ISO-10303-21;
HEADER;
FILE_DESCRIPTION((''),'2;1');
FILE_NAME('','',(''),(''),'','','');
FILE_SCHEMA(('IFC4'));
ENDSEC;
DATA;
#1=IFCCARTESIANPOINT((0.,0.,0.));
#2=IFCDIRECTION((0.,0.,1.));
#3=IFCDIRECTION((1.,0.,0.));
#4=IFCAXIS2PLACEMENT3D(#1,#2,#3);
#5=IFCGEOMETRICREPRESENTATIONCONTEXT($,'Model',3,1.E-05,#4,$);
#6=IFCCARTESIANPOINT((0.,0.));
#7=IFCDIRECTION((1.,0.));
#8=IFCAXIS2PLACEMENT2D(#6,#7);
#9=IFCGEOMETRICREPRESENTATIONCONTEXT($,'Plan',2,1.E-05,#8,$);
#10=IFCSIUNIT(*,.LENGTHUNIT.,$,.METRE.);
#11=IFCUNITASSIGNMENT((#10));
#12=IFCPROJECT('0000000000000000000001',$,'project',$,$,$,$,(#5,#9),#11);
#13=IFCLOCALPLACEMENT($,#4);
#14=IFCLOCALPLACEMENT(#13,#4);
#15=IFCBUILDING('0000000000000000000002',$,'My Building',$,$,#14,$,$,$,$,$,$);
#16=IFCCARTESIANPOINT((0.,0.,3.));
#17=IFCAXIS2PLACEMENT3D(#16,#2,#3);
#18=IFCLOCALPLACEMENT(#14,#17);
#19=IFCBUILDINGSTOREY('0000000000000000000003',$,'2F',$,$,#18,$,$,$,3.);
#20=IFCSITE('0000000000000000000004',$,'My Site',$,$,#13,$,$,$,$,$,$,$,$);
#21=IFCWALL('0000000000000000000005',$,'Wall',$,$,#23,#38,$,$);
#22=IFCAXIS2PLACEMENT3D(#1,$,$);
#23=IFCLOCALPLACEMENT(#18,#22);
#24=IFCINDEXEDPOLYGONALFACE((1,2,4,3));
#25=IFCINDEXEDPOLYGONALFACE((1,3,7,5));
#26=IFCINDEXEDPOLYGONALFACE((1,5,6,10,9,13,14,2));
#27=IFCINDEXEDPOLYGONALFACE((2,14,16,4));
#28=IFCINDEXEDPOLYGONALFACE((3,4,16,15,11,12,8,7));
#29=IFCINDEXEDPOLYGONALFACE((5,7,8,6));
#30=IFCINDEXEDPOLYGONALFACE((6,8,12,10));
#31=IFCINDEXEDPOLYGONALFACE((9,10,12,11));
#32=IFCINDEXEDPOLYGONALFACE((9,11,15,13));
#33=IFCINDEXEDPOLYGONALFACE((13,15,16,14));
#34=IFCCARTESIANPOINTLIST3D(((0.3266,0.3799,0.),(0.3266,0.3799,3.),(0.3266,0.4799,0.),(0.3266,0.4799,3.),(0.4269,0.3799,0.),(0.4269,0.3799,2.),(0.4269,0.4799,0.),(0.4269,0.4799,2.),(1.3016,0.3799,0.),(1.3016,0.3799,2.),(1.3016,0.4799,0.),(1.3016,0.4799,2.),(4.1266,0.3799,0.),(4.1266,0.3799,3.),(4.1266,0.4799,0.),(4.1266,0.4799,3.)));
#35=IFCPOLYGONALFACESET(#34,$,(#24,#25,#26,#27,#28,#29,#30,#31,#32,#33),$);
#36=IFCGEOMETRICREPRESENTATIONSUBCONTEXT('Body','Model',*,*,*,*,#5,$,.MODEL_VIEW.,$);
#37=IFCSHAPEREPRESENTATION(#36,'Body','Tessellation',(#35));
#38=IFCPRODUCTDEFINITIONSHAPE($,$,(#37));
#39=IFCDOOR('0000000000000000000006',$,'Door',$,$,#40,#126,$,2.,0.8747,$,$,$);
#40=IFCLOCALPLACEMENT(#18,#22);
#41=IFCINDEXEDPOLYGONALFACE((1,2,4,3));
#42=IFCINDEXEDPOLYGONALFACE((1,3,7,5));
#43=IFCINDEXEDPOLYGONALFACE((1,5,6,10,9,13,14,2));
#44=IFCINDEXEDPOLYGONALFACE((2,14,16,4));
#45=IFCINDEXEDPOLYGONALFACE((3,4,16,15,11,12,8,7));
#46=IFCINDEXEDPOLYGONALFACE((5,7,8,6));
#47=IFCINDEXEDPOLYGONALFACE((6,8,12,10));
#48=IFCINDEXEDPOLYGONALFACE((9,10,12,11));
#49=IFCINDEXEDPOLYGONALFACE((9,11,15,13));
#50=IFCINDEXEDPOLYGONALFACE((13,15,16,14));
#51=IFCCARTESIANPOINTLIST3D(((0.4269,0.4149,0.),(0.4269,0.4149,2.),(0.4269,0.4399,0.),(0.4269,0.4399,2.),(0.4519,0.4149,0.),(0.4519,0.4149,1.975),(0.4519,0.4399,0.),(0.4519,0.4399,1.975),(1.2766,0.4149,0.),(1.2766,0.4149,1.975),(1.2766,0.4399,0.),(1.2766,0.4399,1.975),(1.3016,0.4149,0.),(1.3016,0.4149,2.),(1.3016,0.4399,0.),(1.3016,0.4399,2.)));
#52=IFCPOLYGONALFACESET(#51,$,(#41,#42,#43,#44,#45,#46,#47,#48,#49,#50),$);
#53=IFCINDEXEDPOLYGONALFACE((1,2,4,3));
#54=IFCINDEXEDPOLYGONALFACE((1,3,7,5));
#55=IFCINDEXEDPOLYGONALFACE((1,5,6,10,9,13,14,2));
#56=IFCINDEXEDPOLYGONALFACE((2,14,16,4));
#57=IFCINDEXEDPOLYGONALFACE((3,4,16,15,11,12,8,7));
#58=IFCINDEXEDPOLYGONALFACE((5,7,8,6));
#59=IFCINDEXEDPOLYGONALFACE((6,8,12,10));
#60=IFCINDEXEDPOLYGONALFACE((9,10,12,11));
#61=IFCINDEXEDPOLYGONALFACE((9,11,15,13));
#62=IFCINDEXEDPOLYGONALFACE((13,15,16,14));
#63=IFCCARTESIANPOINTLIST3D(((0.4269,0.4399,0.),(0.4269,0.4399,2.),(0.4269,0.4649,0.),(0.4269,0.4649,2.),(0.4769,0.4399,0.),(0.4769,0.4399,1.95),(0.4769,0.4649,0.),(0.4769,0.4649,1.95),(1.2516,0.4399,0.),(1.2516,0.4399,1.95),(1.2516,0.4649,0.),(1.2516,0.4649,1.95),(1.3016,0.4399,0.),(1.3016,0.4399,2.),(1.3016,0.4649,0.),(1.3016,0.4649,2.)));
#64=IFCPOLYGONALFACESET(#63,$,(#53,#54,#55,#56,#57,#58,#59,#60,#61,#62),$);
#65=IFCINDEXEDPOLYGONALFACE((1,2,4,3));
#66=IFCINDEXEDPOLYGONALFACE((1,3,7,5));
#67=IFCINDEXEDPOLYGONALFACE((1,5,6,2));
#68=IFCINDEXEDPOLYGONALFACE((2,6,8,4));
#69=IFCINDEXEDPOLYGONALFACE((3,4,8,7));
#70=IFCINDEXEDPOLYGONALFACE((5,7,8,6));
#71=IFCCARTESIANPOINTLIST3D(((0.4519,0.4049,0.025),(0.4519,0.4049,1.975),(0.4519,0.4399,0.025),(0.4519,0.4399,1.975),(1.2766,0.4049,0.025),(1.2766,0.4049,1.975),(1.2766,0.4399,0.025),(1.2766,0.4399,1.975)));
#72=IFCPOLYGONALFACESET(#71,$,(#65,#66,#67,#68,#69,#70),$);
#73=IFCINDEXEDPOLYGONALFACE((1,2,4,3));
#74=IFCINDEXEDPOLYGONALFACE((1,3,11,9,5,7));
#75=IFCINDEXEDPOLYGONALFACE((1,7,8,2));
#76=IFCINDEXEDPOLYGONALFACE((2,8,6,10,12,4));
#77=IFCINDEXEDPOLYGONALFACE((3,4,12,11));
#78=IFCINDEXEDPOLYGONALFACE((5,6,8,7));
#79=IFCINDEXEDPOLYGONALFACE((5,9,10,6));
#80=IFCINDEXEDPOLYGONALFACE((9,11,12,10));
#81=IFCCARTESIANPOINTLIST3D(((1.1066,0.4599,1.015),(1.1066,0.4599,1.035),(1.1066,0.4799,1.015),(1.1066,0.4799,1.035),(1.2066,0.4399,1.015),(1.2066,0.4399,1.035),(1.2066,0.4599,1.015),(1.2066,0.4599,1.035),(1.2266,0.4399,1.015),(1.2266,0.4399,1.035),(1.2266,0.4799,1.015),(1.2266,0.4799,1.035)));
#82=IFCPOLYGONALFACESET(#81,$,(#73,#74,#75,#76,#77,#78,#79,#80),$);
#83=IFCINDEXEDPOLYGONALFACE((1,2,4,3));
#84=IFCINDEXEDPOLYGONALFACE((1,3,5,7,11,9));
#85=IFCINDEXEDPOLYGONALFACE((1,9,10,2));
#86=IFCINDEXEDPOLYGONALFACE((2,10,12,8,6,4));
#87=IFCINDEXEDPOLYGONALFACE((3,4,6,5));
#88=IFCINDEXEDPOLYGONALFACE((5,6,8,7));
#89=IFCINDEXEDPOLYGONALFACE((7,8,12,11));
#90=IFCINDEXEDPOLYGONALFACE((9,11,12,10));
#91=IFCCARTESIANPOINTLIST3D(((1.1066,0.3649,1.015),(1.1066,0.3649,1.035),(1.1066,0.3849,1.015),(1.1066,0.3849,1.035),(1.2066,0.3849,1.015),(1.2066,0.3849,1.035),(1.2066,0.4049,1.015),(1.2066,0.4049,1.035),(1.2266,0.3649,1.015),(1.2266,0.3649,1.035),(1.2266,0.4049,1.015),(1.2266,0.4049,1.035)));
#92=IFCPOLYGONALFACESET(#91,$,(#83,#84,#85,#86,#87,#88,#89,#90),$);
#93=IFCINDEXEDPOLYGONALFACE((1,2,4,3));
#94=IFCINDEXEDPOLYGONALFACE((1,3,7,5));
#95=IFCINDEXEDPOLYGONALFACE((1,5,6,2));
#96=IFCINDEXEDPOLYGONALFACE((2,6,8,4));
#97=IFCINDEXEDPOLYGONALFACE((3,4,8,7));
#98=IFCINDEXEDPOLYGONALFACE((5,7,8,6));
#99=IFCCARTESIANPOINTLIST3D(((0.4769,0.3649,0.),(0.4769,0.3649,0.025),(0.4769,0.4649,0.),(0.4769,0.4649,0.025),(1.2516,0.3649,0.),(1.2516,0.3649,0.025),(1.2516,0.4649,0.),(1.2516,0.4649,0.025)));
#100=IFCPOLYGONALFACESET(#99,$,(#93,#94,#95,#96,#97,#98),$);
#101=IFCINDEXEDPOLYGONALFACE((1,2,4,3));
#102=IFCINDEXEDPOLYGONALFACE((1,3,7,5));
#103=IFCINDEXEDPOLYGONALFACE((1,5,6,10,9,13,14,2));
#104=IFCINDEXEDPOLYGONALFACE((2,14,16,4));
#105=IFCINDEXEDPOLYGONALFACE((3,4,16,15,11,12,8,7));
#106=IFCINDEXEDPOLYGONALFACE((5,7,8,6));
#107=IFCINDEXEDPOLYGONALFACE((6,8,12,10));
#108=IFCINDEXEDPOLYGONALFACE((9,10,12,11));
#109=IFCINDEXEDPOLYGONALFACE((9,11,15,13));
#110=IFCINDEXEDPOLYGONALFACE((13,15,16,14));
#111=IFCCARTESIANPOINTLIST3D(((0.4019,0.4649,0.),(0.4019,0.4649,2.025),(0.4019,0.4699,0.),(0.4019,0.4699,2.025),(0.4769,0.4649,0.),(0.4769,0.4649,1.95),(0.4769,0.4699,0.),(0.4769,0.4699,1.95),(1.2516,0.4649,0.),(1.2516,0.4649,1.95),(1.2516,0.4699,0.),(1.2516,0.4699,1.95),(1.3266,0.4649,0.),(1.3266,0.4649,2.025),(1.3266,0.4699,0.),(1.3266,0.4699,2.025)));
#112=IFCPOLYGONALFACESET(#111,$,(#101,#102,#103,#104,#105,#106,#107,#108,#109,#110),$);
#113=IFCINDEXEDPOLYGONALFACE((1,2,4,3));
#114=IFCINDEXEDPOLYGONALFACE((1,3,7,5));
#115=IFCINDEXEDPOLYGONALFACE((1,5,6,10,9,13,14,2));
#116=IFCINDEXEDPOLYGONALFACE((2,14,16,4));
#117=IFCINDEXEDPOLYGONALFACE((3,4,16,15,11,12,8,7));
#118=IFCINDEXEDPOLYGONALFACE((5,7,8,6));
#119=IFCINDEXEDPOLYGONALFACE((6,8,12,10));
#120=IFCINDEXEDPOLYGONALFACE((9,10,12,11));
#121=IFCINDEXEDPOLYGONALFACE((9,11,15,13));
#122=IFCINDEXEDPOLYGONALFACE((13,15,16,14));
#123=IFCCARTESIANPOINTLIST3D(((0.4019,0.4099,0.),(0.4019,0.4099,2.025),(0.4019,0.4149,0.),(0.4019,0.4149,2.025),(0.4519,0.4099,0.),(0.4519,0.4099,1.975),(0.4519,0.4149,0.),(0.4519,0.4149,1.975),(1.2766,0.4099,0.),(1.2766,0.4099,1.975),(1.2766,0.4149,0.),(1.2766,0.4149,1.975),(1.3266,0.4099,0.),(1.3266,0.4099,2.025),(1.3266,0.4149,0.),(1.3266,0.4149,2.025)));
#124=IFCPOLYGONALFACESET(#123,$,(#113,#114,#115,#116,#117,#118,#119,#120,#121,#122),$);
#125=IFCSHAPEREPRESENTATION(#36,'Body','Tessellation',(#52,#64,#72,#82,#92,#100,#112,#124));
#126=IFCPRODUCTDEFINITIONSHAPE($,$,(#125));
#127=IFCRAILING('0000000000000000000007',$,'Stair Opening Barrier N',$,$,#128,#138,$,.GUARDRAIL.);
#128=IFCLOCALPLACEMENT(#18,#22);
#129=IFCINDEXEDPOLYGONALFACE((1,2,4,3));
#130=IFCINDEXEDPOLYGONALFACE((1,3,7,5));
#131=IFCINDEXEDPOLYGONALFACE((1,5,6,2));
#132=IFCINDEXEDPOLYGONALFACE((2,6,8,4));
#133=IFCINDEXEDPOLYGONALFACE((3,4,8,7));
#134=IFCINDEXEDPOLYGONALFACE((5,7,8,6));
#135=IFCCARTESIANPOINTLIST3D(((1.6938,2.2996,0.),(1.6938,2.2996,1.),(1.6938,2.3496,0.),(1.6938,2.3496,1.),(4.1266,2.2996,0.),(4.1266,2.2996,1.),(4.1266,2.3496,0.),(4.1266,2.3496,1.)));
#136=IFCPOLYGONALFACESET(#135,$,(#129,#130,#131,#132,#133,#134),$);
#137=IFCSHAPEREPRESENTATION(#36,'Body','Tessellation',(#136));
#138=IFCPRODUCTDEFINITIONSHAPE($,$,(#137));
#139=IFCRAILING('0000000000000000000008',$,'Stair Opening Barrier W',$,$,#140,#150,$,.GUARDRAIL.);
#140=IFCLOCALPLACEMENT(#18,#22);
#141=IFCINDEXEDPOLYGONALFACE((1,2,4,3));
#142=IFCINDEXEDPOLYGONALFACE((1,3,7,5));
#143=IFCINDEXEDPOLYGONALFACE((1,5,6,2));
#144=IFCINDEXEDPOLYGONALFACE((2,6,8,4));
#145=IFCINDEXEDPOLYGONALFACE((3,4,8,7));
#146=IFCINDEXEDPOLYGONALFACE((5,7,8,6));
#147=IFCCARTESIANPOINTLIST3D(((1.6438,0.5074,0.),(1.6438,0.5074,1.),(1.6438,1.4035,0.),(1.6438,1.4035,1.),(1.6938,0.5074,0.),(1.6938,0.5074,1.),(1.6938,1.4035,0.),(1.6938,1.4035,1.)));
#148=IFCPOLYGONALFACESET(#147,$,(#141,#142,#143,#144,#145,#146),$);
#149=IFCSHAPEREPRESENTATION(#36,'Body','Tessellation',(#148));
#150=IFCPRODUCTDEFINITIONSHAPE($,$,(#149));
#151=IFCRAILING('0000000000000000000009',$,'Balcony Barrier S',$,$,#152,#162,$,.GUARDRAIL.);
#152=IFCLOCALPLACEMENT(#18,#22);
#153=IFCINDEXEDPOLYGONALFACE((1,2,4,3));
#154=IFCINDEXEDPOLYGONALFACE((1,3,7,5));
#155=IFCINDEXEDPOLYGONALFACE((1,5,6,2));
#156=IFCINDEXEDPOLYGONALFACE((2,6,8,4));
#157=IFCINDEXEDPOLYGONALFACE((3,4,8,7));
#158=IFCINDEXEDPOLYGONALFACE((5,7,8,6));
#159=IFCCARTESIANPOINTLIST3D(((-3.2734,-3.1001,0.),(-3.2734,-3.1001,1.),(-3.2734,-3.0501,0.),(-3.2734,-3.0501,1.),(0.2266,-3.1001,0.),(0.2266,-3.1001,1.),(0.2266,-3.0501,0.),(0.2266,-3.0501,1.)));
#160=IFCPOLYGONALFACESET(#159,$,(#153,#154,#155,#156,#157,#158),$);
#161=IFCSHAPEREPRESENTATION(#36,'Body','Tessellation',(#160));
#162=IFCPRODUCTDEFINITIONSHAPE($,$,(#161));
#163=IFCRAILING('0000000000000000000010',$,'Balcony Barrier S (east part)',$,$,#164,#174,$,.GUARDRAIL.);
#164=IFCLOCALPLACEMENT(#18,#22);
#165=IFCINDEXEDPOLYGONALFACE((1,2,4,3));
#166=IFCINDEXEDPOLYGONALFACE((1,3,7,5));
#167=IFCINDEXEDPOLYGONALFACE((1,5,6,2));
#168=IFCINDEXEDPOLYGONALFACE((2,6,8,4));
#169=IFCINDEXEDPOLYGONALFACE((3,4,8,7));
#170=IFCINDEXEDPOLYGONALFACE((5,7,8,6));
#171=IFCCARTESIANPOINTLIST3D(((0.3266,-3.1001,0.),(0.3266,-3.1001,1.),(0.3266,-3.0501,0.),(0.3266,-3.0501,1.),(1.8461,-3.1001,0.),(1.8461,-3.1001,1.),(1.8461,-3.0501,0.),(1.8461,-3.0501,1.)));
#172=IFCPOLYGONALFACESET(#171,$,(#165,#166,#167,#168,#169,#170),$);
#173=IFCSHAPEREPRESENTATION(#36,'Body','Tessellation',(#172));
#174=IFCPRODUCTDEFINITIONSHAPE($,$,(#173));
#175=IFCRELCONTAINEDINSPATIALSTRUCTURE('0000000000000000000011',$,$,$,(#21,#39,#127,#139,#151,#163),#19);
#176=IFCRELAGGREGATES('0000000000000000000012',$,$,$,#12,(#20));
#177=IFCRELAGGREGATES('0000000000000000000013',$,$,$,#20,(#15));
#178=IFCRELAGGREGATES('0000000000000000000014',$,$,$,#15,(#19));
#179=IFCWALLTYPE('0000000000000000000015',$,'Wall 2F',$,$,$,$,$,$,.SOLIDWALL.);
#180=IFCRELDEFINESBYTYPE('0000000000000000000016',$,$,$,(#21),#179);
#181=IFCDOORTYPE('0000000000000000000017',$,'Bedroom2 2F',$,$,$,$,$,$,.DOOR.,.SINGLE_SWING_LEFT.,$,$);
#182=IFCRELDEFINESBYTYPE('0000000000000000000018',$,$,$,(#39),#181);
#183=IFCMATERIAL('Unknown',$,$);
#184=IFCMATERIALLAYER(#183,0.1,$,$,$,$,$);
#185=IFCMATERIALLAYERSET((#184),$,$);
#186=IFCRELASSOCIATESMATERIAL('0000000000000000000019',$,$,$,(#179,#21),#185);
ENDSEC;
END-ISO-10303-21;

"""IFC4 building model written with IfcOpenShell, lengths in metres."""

from ifc_helpers import new_model, entity, si_unit, frame, origin_with_axes, origin_2d_with_axis, place, context, subcontext, project, spatial, polyline, line, indexed_curve, outline, extrude, shape, source, transform, mapped, material, layer, layer_set, layer_usage, type_object, type_shapes, element, fill, save


model = new_model("IFC4")

# Units and contexts
model_context = context("Model", 3, precision=1e-05, world=origin_with_axes())
plan_context = context("Plan", 2, precision=1e-05, world=origin_2d_with_axis())
body_context_1 = subcontext(model_context, "Body", "Model", "MODEL_VIEW")
body_context_2 = subcontext(plan_context, "Body", "Plan", "PLAN_VIEW")
ifc_project = project(units=[si_unit("LENGTHUNIT", "METRE")], contexts=[model_context, plan_context])

# Site, building, storey
site_placement = place(None, origin_with_axes())
site = spatial("IfcSite", under=ifc_project, at=site_placement, Name="My Site")
building_placement = place(site_placement, origin_with_axes())
building = spatial("IfcBuilding", under=site, at=building_placement, Name="My Building")
storey_placement = place(building_placement, frame((0.0, 0.0, 3.0), z_axis=(0.0, 0.0, 1.0), x_axis=(1.0, 0.0, 0.0)))
storey = spatial("IfcBuildingStorey", under=building, at=storey_placement, Name="2F", Elevation=3.0)

# Shared definitions
ifc_material = material(Name="Unknown")

# Shared definitions
ifc_layer_1 = layer(ifc_material, 0.1)
ifc_layer_set_1 = layer_set([ifc_layer_1])
wall_type = type_object("IfcWallType", Name="Wall 2F", PredefinedType="SOLIDWALL", material=ifc_layer_set_1)

# Wall, opening, door
ifc_layer_usage_1 = layer_usage(ifc_layer_set_1, "AXIS2", "POSITIVE", 0.0)
wall_1_placement = place(storey_placement, frame((4.1266, 0.4799, 0.0), z_axis=(0.0, 0.0, 1.0), x_axis=(-1.0, 0.0, 0.0)))
wall_1 = element("IfcWall", 1, at=wall_1_placement, inside=storey, type_object=wall_type, material=ifc_layer_usage_1, Name="Wall", context=body_context_1, shape_type="SweptSolid", body=[
    extrude(outline(polyline([(0.0, 0.0), (3.8, 0.0), (3.8, 0.1), (0.0, 0.1), (0.0, 0.0)])), origin_with_axes(), (0.0, 0.0, 1.0), 3.0),
])
opening_1_placement = place(wall_1_placement, frame((2.825, 0.015, 0.0), z_axis=(0.0, 0.0, 1.0), x_axis=(1.0, 0.0, 0.0)))
opening_1 = element("IfcOpeningElement", 2, at=opening_1_placement, cuts=wall_1, PredefinedType="OPENING", context=body_context_1, shape_type="SweptSolid", body=[
    extrude(outline(polyline([(0.0, 0.0), (0.8747, 0.0), (0.8747, 2.0), (0.0, 2.0), (0.0, 0.0)])), frame((0.0, -0.6, 0.0), z_axis=(0.0, -1.0, 0.0), x_axis=(1.0, 0.0, 0.0)), (0.0, 0.0, -1.0), 1.2),
])
door_type_1 = type_object("IfcDoorType", Name="Bedroom2 2F", OperationType="SINGLE_SWING_LEFT", PredefinedType="DOOR")
shared_shape_1 = source(origin_with_axes(), body_context_1, "Body", "SweptSolid", [
    extrude(outline(indexed_curve([(0.0, 0.0), (0.0, 2.0), (0.8747, 2.0), (0.8747, 0.0), (0.8497, 0.0), (0.8497, 1.975), (0.025, 1.975), (0.025, 0.0)], segments=[line(1, 2, 3, 4, 5, 6, 7, 8, 1)])), frame((0.0, 0.025, 0.0), z_axis=(0.0, -1.0, 0.0), x_axis=(1.0, 0.0, 0.0)), (0.0, 0.0, -1.0), 0.025),
    extrude(outline(indexed_curve([(0.0, 0.0), (0.0, 2.0), (0.8747, 2.0), (0.8747, 0.0), (0.8247, 0.0), (0.8247, 1.95), (0.05, 1.95), (0.05, 0.0)], segments=[line(1, 2, 3, 4, 5, 6, 7, 8, 1)])), frame((0.0, 0.0, 0.0), z_axis=(0.0, -1.0, 0.0), x_axis=(1.0, 0.0, 0.0)), (0.0, 0.0, -1.0), 0.025),
    extrude(outline(indexed_curve([(0.0, 0.0), (0.8247, 0.0), (0.8247, 0.035), (0.0, 0.035)], segments=[line(1, 2, 3, 4, 1)])), frame((0.025, 0.025, 0.025), z_axis=(0.0, 0.0, 1.0), x_axis=(1.0, 0.0, 0.0)), (0.0, 0.0, 1.0), 1.95),
    extrude(outline(indexed_curve([(0.0, 0.0), (0.0, -0.04), (0.12, -0.04), (0.12, -0.02), (0.02, -0.02), (0.02, 0.0)], segments=[line(1, 2, 3, 4, 5, 6, 1)])), frame((0.075, 0.025, 1.015), z_axis=(0.0, 0.0, 1.0), x_axis=(1.0, 0.0, 0.0)), (0.0, 0.0, 1.0), 0.02),
    extrude(outline(indexed_curve([(0.0, 0.0), (0.0, 0.04), (0.12, 0.04), (0.12, 0.02), (0.02, 0.02), (0.02, 0.0)], segments=[line(1, 2, 3, 4, 5, 6, 1)])), frame((0.075, 0.06, 1.015), z_axis=(0.0, 0.0, 1.0), x_axis=(1.0, 0.0, 0.0)), (0.0, 0.0, 1.0), 0.02),
    extrude(outline(indexed_curve([(0.0, 0.0), (0.7747, 0.0), (0.7747, 0.1), (0.0, 0.1)], segments=[line(1, 2, 3, 4, 1)])), frame((0.05, 0.0, 0.0), z_axis=(0.0, 0.0, 1.0), x_axis=(1.0, 0.0, 0.0)), (0.0, 0.0, 1.0), 0.025),
    extrude(outline(indexed_curve([(0.0, 0.0), (0.0, 2.025), (0.9247, 2.025), (0.9247, 0.0), (0.8497, 0.0), (0.8497, 1.95), (0.075, 1.95), (0.075, 0.0)], segments=[line(1, 2, 3, 4, 5, 6, 7, 8, 1)])), frame((-0.025, -0.005, 0.0), z_axis=(0.0, -1.0, 0.0), x_axis=(1.0, 0.0, 0.0)), (0.0, 0.0, -1.0), 0.005),
    extrude(outline(indexed_curve([(0.0, 0.0), (0.0, 2.025), (0.9247, 2.025), (0.9247, 0.0), (0.8747, 0.0), (0.8747, 1.975), (0.05, 1.975), (0.05, 0.0)], segments=[line(1, 2, 3, 4, 5, 6, 7, 8, 1)])), frame((-0.025, 0.05, 0.0), z_axis=(0.0, -1.0, 0.0), x_axis=(1.0, 0.0, 0.0)), (0.0, 0.0, -1.0), 0.005),
])
shared_shape_2 = source(origin_with_axes(), body_context_2, "Body", "Curve2D", [
    entity("IfcIndexedPolyCurve", entity("IfcCartesianPointList2D", [[0.0, 0.0], [0.0, 0.05], [0.025, 0.05], [0.025, 0.025], [0.05, 0.025], [0.05, 0.0]]), [entity("IfcLineIndex", [1, 2, 3, 4, 5, 6, 1])]),
    entity("IfcIndexedPolyCurve", entity("IfcCartesianPointList2D", [[0.8747, 0.0], [0.8747, 0.05], [0.8497, 0.05], [0.8497, 0.025], [0.8247, 0.025], [0.8247, 0.0]]), [entity("IfcLineIndex", [1, 2, 3, 4, 5, 6, 1])]),
    entity("IfcTrimmedCurve", entity("IfcEllipse", entity("IfcAxis2Placement2D", entity("IfcCartesianPoint", [0.8147, 0.05]), entity("IfcDirection", [1.0, 0.0])), 0.7897, 0.8247), [entity("IfcCartesianPoint", [0.8147, 0.8747])], [entity("IfcCartesianPoint", [0.025, 0.05])], True, "CARTESIAN"),
    entity("IfcIndexedPolyCurve", entity("IfcCartesianPointList2D", [[0.8497, 0.05], [0.8147, 0.05], [0.8147, 0.8747], [0.8497, 0.8747]]), [entity("IfcLineIndex", [1, 2, 3, 4, 1])]),
])
type_shapes(door_type_1, [shared_shape_1, shared_shape_2])
door_1_placement = place(storey_placement, frame((1.3016, 0.4649, 0.0), z_axis=(0.0, 0.0, 1.0), x_axis=(-1.0, 0.0, 0.0)))
door_1 = element("IfcDoor", 3, at=door_1_placement, inside=storey, type_object=door_type_1, Name="Door", OverallHeight=2.0, OverallWidth=0.8747, shapes=[
    shape(body_context_1, "Body", "MappedRepresentation", [mapped(shared_shape_1, transform((0.0, 0.0, 0.0), x_axis=(1.0, 0.0, 0.0), y_axis=(0.0, 1.0, 0.0), z_axis=(0.0, 0.0, 1.0), scale=1.0))]),
    shape(body_context_2, "Body", "MappedRepresentation", [mapped(shared_shape_2, transform((0.0, 0.0, 0.0), x_axis=(1.0, 0.0, 0.0), y_axis=(0.0, 1.0, 0.0), z_axis=(0.0, 0.0, 1.0), scale=1.0))]),
])
fill(opening_1, door_1)

# Railings
railing_1_placement = place(storey_placement, frame((1.6938, 2.3496, 0.0), z_axis=(0.0, -1.0, 0.0), x_axis=(1.0, 0.0, 0.0)))
element("IfcRailing", 4, at=railing_1_placement, inside=storey, Name="Stair Opening Barrier N", PredefinedType="GUARDRAIL", context=body_context_1, shape_type="SweptSolid", body=[
    extrude(outline(polyline([(0.0, 0.0), (2.4329, 0.0), (2.4329, 1.0), (0.0, 1.0), (0.0, 0.0)])), origin_with_axes(), (0.0, 0.0, 1.0), 0.05),
])
railing_2_placement = place(storey_placement, frame((1.6438, 0.5074, 0.0), z_axis=(1.0, 0.0, 0.0), x_axis=(0.0, 1.0, 0.0)))
element("IfcRailing", 5, at=railing_2_placement, inside=storey, Name="Stair Opening Barrier W", PredefinedType="GUARDRAIL", context=body_context_1, shape_type="SweptSolid", body=[
    extrude(outline(polyline([(0.0, 0.0), (0.8961, 0.0), (0.8961, 1.0), (0.0, 1.0), (0.0, 0.0)])), origin_with_axes(), (0.0, 0.0, 1.0), 0.05),
])
railing_3_placement = place(storey_placement, frame((-3.2734, -3.0501, 0.0), z_axis=(0.0, -1.0, 0.0), x_axis=(1.0, 0.0, 0.0)))
element("IfcRailing", 6, at=railing_3_placement, inside=storey, Name="Balcony Barrier S", PredefinedType="GUARDRAIL", context=body_context_1, shape_type="SweptSolid", body=[
    extrude(outline(polyline([(0.0, 0.0), (3.5, 0.0), (3.5, 1.0), (0.0, 1.0), (0.0, 0.0)])), origin_with_axes(), (0.0, 0.0, 1.0), 0.05),
])
railing_4_placement = place(storey_placement, frame((0.3266, -3.0501, 0.0), z_axis=(0.0, -1.0, 0.0), x_axis=(1.0, 0.0, 0.0)))
element("IfcRailing", 7, at=railing_4_placement, inside=storey, Name="Balcony Barrier S (east part)", PredefinedType="GUARDRAIL", context=body_context_1, shape_type="SweptSolid", body=[
    extrude(outline(polyline([(0.0, 0.0), (1.5195, 0.0), (1.5195, 1.0), (0.0, 1.0), (0.0, 0.0)])), origin_with_axes(), (0.0, 0.0, 1.0), 0.05),
])

save(model, "model.ifc")
